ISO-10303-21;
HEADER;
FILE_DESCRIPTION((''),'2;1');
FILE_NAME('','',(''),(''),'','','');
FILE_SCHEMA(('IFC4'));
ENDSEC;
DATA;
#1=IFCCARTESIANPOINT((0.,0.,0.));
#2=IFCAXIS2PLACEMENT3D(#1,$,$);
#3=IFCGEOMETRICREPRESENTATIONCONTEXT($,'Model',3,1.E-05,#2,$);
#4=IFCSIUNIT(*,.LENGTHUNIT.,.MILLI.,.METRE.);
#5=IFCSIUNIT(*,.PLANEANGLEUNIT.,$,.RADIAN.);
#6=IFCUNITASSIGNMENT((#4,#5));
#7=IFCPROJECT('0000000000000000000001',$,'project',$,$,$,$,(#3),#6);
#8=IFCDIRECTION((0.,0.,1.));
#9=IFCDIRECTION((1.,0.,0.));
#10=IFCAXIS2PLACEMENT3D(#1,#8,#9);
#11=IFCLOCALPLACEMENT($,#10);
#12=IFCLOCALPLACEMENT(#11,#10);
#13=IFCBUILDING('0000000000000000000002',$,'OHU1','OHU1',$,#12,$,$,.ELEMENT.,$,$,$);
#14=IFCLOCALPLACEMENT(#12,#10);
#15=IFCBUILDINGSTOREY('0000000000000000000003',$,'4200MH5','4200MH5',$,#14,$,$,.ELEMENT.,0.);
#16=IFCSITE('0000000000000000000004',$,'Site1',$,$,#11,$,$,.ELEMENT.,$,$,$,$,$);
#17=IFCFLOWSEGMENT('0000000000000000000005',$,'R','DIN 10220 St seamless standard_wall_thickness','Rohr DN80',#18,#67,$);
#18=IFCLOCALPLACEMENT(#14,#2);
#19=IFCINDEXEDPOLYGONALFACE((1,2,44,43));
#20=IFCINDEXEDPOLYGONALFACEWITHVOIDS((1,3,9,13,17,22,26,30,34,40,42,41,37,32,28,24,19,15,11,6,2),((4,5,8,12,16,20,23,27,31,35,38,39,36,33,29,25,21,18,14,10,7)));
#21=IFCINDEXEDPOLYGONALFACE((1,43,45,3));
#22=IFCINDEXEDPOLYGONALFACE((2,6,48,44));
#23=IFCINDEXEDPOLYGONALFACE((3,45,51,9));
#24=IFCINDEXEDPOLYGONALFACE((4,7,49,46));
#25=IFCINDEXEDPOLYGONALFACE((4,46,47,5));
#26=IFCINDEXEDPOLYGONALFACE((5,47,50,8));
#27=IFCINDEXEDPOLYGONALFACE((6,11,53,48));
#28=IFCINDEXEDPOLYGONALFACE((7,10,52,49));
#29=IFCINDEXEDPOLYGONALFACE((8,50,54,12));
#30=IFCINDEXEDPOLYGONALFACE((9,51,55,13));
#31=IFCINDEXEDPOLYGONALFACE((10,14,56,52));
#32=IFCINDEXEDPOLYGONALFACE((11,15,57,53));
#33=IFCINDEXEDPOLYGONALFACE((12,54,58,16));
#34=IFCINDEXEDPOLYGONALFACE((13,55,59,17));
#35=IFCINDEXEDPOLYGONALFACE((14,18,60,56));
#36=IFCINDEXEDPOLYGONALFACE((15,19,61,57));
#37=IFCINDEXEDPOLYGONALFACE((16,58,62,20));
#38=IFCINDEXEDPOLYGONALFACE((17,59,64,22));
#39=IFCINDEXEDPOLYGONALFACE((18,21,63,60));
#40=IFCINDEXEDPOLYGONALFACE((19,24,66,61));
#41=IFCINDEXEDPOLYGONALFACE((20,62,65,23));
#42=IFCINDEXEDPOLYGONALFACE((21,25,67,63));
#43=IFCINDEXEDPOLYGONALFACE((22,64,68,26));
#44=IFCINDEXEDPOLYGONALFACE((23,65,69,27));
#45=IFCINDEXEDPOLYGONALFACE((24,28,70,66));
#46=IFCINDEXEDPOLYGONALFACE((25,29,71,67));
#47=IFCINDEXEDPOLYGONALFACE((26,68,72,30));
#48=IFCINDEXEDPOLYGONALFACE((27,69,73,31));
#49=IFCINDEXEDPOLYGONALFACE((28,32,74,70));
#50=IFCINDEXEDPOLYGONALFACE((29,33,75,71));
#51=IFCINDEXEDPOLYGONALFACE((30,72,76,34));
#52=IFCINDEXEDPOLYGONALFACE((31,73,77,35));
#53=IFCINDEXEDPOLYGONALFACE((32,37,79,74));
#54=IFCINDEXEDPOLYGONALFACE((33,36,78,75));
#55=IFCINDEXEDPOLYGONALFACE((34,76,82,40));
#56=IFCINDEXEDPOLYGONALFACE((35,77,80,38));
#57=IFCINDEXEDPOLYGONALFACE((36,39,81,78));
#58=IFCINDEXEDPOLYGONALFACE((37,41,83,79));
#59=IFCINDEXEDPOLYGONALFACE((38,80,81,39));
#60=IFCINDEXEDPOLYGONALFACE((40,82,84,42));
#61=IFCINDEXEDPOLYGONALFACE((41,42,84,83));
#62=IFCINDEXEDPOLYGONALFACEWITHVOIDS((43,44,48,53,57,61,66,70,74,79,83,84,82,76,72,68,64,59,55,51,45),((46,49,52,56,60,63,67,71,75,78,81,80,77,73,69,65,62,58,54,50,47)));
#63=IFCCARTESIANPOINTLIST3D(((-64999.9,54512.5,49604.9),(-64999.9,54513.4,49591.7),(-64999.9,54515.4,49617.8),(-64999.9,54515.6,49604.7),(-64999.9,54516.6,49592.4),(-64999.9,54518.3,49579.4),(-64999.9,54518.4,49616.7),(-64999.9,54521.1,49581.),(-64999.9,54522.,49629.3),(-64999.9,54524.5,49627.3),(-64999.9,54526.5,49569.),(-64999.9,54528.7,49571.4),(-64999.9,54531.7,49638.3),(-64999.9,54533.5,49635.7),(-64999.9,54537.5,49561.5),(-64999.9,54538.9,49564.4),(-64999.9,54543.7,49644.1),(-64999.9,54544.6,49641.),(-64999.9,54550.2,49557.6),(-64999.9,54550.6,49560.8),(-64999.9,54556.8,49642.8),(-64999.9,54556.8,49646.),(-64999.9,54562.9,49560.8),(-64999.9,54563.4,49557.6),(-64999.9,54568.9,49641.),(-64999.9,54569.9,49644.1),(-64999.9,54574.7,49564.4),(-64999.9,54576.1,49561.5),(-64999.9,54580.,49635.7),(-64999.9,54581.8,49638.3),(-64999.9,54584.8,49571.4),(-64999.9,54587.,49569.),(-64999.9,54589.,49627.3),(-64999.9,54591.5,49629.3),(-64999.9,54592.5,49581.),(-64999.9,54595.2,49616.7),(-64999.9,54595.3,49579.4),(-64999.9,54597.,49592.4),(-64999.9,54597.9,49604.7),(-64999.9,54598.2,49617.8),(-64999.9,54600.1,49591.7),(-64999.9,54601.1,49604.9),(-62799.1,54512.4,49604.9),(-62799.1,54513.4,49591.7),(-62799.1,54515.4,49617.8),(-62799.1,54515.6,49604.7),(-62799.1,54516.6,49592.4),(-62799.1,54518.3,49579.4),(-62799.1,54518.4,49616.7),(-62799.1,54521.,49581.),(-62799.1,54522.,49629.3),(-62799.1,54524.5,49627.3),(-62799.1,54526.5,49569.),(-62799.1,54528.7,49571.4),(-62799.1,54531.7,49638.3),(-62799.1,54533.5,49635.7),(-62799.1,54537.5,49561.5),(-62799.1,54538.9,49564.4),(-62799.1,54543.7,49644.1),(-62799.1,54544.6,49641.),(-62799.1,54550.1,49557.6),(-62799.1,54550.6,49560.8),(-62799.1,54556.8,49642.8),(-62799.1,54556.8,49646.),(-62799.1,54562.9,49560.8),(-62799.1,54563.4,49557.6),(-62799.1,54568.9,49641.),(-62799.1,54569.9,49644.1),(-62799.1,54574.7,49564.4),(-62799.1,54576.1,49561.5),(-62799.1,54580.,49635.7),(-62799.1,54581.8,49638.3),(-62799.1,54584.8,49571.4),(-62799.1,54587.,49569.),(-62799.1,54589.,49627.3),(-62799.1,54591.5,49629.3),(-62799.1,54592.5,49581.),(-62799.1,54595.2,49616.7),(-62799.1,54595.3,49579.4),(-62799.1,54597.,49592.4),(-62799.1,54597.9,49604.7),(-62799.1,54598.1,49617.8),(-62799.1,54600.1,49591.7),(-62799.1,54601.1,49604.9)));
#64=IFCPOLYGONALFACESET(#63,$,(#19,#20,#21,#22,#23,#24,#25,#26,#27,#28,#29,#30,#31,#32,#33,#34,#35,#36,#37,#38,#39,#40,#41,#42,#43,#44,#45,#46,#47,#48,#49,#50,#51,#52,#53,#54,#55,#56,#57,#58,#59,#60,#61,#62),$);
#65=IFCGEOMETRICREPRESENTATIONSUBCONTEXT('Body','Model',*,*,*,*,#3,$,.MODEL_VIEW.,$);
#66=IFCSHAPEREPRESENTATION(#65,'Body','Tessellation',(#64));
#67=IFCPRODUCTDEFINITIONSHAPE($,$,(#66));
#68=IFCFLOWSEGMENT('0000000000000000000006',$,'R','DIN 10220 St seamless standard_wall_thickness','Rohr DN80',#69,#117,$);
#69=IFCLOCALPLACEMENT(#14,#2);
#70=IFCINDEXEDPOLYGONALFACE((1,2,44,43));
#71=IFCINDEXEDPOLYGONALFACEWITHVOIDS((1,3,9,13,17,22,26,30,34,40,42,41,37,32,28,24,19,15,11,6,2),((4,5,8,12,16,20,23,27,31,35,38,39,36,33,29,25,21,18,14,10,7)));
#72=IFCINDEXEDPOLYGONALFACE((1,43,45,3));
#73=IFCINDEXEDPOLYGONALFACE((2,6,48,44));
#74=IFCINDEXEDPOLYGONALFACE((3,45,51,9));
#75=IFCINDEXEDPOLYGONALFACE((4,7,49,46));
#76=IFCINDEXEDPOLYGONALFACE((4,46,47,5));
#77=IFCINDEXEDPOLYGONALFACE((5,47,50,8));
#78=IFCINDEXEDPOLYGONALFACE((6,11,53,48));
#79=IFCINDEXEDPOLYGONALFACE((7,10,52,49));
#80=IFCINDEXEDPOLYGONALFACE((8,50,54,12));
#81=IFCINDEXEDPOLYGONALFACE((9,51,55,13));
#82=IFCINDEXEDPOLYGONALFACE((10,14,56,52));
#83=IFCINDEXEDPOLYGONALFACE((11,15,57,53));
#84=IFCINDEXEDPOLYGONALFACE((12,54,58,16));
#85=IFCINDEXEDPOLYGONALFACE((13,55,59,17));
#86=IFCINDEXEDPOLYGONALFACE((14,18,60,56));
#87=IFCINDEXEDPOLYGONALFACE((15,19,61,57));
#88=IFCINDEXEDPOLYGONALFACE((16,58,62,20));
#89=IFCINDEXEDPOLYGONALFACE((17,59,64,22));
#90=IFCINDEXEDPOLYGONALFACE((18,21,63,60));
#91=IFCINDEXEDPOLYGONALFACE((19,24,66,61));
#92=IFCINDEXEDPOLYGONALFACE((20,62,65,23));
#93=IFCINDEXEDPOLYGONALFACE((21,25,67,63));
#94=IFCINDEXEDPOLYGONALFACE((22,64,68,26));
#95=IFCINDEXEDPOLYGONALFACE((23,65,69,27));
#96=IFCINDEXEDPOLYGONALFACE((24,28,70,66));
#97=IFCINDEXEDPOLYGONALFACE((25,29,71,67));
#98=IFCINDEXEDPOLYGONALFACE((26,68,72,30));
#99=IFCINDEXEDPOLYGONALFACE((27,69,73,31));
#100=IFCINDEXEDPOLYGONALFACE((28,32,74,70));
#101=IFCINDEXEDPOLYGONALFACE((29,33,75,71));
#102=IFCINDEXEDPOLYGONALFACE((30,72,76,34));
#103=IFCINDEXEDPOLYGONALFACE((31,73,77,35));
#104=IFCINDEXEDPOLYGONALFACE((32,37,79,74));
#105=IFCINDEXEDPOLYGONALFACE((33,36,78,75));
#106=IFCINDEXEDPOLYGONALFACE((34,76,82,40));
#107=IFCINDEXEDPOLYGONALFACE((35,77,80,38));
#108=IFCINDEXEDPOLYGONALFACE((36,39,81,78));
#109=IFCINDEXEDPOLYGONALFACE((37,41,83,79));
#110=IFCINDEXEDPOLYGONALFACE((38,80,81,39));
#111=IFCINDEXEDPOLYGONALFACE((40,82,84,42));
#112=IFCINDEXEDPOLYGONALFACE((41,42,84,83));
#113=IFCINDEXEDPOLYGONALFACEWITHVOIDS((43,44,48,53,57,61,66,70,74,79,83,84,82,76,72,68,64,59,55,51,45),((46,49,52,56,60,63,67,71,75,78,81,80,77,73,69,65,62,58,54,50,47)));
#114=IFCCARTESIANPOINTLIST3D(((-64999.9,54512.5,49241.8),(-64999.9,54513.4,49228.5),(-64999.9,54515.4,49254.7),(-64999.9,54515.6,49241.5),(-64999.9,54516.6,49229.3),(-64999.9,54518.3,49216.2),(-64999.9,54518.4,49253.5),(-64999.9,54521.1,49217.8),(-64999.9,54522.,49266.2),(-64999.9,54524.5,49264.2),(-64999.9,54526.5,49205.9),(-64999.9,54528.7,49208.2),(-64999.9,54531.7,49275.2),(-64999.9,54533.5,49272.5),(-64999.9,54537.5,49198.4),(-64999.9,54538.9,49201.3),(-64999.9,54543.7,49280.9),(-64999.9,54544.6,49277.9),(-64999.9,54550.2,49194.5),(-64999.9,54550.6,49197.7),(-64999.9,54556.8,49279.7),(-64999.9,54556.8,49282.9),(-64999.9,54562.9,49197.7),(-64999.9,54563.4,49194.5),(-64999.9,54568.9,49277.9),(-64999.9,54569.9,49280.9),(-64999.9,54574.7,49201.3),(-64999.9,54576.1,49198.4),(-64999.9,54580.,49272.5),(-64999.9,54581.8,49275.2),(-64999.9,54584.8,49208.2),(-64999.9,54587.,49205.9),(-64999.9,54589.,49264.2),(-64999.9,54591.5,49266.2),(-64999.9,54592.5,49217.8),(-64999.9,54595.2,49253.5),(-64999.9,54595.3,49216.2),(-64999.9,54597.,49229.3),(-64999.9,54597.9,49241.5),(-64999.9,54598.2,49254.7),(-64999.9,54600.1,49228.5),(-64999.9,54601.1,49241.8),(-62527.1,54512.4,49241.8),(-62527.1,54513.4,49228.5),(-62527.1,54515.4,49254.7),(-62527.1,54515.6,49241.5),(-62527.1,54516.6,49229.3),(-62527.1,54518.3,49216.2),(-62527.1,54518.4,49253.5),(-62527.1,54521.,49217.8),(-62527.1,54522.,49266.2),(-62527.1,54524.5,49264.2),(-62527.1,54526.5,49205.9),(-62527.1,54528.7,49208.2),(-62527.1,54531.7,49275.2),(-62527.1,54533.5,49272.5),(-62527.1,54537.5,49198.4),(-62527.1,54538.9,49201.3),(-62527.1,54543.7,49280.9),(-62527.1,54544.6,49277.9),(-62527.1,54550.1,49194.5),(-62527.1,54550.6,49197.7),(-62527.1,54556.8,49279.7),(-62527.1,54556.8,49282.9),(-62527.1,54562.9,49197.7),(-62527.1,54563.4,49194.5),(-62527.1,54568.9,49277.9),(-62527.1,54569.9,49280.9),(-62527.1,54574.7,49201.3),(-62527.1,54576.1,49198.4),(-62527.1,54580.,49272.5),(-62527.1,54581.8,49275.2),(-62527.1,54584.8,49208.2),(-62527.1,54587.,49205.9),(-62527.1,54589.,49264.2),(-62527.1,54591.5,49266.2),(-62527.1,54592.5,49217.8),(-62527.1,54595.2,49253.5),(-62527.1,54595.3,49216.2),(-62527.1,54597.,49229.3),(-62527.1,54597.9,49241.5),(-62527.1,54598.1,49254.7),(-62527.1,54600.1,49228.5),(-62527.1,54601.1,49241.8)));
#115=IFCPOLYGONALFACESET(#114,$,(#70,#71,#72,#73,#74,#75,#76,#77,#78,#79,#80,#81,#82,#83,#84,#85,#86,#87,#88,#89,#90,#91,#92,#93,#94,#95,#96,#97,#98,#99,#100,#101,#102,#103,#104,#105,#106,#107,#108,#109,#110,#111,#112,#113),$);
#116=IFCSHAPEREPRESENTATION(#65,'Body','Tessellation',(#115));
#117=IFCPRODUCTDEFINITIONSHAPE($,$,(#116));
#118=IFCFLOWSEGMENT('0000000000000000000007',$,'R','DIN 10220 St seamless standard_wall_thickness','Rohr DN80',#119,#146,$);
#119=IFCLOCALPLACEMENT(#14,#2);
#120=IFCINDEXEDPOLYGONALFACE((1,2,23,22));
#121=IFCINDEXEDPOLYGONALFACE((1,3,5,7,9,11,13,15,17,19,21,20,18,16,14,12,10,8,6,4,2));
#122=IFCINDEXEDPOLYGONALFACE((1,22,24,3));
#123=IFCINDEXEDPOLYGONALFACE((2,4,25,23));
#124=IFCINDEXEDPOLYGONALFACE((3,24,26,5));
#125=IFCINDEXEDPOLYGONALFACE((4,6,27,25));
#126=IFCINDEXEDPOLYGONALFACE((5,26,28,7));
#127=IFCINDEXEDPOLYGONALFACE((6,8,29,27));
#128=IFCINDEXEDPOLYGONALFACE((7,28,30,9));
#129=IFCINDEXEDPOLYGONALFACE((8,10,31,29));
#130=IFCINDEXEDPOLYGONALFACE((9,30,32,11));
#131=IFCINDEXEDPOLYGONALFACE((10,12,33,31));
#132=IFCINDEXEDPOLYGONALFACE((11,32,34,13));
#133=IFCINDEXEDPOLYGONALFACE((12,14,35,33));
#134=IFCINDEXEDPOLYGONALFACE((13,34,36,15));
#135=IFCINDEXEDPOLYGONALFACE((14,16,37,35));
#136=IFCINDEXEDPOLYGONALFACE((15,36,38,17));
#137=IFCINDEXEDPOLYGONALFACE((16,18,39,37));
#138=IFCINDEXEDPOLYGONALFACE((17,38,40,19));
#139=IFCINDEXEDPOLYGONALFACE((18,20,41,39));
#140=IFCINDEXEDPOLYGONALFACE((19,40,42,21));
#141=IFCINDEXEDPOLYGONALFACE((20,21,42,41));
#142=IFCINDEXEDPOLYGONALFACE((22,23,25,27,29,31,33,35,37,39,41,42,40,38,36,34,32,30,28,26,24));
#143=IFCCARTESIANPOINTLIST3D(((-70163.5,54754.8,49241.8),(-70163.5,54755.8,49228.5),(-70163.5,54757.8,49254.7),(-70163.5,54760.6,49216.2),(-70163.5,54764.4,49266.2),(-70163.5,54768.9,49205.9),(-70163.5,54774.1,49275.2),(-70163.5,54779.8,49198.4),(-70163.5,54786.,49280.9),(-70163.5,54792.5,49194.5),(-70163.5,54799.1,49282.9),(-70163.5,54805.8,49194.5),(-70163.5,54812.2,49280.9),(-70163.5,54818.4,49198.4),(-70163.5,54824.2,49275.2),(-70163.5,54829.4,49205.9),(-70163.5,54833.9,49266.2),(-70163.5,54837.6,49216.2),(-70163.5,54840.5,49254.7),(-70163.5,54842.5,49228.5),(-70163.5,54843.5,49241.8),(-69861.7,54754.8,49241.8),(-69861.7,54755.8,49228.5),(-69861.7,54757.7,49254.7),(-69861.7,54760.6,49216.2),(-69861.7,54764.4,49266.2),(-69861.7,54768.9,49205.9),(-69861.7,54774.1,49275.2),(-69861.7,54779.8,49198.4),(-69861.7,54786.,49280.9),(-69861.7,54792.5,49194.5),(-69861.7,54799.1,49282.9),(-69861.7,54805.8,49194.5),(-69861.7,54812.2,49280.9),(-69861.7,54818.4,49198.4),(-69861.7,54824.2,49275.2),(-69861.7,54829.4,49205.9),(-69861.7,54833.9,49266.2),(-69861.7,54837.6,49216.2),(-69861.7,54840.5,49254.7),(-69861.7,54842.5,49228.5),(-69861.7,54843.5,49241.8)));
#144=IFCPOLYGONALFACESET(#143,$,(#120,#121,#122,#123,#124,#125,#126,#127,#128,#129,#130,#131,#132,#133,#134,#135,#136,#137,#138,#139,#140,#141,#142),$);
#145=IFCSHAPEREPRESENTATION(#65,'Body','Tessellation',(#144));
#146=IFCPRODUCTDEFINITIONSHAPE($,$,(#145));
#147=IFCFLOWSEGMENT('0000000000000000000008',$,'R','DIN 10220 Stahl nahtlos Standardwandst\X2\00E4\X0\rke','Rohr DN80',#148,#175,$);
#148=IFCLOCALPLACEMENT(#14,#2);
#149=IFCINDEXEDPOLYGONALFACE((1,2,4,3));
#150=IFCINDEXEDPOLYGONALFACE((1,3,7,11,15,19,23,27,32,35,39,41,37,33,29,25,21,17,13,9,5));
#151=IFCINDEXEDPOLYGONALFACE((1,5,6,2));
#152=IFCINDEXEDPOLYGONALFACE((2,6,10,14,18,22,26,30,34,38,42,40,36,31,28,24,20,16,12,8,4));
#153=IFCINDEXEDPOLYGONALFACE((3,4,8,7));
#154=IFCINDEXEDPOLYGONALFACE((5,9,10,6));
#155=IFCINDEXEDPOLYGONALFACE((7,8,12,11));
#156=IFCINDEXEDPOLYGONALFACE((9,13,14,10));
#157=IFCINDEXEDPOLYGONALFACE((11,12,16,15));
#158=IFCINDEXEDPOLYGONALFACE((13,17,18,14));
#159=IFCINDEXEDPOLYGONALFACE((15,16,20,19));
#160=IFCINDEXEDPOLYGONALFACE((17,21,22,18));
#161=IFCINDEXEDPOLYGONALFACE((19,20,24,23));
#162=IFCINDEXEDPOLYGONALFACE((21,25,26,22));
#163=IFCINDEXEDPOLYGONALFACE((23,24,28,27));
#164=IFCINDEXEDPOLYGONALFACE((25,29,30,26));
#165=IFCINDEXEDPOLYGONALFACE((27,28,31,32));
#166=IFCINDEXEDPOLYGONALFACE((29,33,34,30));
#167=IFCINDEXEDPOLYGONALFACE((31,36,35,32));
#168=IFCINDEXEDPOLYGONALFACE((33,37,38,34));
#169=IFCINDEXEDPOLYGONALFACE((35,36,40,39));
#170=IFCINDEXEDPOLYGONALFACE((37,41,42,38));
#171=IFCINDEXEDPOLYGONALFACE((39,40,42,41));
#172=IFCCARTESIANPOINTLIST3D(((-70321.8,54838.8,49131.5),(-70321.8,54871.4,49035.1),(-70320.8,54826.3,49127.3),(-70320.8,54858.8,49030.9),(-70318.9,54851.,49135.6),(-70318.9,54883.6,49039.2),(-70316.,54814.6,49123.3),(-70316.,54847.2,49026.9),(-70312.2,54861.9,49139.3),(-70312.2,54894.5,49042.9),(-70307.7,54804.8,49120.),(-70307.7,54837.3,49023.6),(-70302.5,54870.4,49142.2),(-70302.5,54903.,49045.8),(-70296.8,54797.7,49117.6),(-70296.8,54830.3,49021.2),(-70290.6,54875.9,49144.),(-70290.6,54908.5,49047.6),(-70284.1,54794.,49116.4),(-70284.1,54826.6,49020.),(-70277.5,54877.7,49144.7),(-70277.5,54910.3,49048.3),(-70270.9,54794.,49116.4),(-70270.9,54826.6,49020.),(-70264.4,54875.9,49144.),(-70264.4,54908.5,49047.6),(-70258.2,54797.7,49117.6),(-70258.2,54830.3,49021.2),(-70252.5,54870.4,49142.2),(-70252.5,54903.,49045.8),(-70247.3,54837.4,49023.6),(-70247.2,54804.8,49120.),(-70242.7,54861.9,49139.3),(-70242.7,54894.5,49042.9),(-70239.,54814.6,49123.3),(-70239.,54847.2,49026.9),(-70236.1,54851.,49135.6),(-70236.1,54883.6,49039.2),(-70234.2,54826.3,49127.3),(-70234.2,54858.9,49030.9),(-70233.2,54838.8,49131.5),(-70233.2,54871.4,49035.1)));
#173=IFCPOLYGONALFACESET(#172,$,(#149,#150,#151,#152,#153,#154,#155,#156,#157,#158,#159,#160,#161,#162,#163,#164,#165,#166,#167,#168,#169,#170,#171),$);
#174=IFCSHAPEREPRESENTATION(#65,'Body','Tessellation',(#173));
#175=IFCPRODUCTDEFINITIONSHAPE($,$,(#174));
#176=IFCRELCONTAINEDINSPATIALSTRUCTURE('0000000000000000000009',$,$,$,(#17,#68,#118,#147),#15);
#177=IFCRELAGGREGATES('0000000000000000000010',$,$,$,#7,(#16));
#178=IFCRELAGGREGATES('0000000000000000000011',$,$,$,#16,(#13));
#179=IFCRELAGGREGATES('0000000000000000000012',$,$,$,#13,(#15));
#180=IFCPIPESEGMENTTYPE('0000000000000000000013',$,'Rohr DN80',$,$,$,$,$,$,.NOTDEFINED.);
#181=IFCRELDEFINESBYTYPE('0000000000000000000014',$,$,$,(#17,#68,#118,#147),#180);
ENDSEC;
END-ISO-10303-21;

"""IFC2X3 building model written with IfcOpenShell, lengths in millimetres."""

from ifc_helpers import new_model, si_unit, frame, origin, origin_with_axes, origin_2d_with_axis, place, context, subcontext, project, spatial, circle, hollow_circle, extrude, type_object, element, save


model = new_model("IFC2X3")

# Units and contexts
model_context = context("Model", 3, precision=1e-05, world=origin())
body_context = subcontext(model_context, "Body", "Model", "MODEL_VIEW")
ifc_project = project(units=[si_unit("LENGTHUNIT", "METRE", prefix="MILLI"), si_unit("PLANEANGLEUNIT", "RADIAN")], contexts=[model_context])

# Site, building, storey
site_placement = place(None, origin_with_axes())
site = spatial("IfcSite", under=ifc_project, at=site_placement, Name="Site1", CompositionType="ELEMENT")
building_placement = place(site_placement, origin_with_axes())
building = spatial("IfcBuilding", under=site, at=building_placement, Name="OHU1", Description="OHU1", CompositionType="ELEMENT")
storey_placement = place(building_placement, origin_with_axes())
storey = spatial("IfcBuildingStorey", under=building, at=storey_placement, Name="4200MH5", Description="4200MH5", CompositionType="ELEMENT", Elevation=0.0)

# Flow segments
pipe_segment_type_1 = type_object("IfcPipeSegmentType", Name="Rohr DN80", PredefinedType="NOTDEFINED")
flow_segment_1_placement = place(storey_placement, frame((-63899.5, 54556.8, 49601.6), z_axis=(0.0, 0.0, 1.0), x_axis=(1.0, 0.0, 0.0)))
element("IfcFlowSegment", 1, at=flow_segment_1_placement, inside=storey, type_object=pipe_segment_type_1, Name="R", Description="DIN 10220 St seamless standard_wall_thickness", ObjectType="Rohr DN80", context=body_context, shape_type="SweptSolid", body=[
    extrude(hollow_circle(Radius=44.5, WallThickness=3.2, at=origin_2d_with_axis()), frame((1100.4, 0.0, 0.0), z_axis=(-1.0, 0.000003, 0.0), x_axis=(0.0, 0.0, 1.0)), (0.0, 0.0, 1.0), 2200.8),
])
flow_segment_2_placement = place(storey_placement, frame((-63763.5, 54556.8, 49238.4), z_axis=(0.0, 0.0, 1.0), x_axis=(1.0, 0.0, 0.0)))
element("IfcFlowSegment", 2, at=flow_segment_2_placement, inside=storey, type_object=pipe_segment_type_1, Name="R", Description="DIN 10220 St seamless standard_wall_thickness", ObjectType="Rohr DN80", context=body_context, shape_type="SweptSolid", body=[
    extrude(hollow_circle(Radius=44.5, WallThickness=3.2, at=origin_2d_with_axis()), frame((1236.4, 0.0, 0.0), z_axis=(-1.0, 0.000003, 0.0), x_axis=(0.0, 0.0, 1.0)), (0.0, 0.0, 1.0), 2472.9),
])
flow_segment_3_placement = place(storey_placement, frame((-70012.6, 54799.0, 49238.4), z_axis=(0.0, 0.0, 1.0), x_axis=(1.0, 0.0, 0.0)))
element("IfcFlowSegment", 3, at=flow_segment_3_placement, inside=storey, type_object=pipe_segment_type_1, Name="R", Description="DIN 10220 St seamless standard_wall_thickness", ObjectType="Rohr DN80", context=body_context, shape_type="SweptSolid", body=[
    extrude(circle(Radius=44.5, at=origin_2d_with_axis()), frame((150.9, 0.1, 0.0), z_axis=(-1.0, 0.000004, 0.0), x_axis=(0.0, 0.0, 1.0)), (0.0, 0.0, 1.0), 301.8),
])
flow_segment_4_placement = place(storey_placement, frame((-70277.6, 54851.9, 49082.2), z_axis=(0.0, 0.0, 1.0), x_axis=(1.0, 0.0, 0.0)))
element("IfcFlowSegment", 4, at=flow_segment_4_placement, inside=storey, type_object=pipe_segment_type_1, Name="R", Description="DIN 10220 Stahl nahtlos Standardwandstärke", ObjectType="Rohr DN80", context=body_context, shape_type="SweptSolid", body=[
    extrude(circle(Radius=44.5, at=origin_2d_with_axis()), frame((0.2, -16.3, 48.2), z_axis=(-0.000045, 0.320225, -0.947341), x_axis=(0.0, 0.0, 1.0)), (0.0, 0.0, 1.0), 101.8),
])

save(model, "model.ifc")
